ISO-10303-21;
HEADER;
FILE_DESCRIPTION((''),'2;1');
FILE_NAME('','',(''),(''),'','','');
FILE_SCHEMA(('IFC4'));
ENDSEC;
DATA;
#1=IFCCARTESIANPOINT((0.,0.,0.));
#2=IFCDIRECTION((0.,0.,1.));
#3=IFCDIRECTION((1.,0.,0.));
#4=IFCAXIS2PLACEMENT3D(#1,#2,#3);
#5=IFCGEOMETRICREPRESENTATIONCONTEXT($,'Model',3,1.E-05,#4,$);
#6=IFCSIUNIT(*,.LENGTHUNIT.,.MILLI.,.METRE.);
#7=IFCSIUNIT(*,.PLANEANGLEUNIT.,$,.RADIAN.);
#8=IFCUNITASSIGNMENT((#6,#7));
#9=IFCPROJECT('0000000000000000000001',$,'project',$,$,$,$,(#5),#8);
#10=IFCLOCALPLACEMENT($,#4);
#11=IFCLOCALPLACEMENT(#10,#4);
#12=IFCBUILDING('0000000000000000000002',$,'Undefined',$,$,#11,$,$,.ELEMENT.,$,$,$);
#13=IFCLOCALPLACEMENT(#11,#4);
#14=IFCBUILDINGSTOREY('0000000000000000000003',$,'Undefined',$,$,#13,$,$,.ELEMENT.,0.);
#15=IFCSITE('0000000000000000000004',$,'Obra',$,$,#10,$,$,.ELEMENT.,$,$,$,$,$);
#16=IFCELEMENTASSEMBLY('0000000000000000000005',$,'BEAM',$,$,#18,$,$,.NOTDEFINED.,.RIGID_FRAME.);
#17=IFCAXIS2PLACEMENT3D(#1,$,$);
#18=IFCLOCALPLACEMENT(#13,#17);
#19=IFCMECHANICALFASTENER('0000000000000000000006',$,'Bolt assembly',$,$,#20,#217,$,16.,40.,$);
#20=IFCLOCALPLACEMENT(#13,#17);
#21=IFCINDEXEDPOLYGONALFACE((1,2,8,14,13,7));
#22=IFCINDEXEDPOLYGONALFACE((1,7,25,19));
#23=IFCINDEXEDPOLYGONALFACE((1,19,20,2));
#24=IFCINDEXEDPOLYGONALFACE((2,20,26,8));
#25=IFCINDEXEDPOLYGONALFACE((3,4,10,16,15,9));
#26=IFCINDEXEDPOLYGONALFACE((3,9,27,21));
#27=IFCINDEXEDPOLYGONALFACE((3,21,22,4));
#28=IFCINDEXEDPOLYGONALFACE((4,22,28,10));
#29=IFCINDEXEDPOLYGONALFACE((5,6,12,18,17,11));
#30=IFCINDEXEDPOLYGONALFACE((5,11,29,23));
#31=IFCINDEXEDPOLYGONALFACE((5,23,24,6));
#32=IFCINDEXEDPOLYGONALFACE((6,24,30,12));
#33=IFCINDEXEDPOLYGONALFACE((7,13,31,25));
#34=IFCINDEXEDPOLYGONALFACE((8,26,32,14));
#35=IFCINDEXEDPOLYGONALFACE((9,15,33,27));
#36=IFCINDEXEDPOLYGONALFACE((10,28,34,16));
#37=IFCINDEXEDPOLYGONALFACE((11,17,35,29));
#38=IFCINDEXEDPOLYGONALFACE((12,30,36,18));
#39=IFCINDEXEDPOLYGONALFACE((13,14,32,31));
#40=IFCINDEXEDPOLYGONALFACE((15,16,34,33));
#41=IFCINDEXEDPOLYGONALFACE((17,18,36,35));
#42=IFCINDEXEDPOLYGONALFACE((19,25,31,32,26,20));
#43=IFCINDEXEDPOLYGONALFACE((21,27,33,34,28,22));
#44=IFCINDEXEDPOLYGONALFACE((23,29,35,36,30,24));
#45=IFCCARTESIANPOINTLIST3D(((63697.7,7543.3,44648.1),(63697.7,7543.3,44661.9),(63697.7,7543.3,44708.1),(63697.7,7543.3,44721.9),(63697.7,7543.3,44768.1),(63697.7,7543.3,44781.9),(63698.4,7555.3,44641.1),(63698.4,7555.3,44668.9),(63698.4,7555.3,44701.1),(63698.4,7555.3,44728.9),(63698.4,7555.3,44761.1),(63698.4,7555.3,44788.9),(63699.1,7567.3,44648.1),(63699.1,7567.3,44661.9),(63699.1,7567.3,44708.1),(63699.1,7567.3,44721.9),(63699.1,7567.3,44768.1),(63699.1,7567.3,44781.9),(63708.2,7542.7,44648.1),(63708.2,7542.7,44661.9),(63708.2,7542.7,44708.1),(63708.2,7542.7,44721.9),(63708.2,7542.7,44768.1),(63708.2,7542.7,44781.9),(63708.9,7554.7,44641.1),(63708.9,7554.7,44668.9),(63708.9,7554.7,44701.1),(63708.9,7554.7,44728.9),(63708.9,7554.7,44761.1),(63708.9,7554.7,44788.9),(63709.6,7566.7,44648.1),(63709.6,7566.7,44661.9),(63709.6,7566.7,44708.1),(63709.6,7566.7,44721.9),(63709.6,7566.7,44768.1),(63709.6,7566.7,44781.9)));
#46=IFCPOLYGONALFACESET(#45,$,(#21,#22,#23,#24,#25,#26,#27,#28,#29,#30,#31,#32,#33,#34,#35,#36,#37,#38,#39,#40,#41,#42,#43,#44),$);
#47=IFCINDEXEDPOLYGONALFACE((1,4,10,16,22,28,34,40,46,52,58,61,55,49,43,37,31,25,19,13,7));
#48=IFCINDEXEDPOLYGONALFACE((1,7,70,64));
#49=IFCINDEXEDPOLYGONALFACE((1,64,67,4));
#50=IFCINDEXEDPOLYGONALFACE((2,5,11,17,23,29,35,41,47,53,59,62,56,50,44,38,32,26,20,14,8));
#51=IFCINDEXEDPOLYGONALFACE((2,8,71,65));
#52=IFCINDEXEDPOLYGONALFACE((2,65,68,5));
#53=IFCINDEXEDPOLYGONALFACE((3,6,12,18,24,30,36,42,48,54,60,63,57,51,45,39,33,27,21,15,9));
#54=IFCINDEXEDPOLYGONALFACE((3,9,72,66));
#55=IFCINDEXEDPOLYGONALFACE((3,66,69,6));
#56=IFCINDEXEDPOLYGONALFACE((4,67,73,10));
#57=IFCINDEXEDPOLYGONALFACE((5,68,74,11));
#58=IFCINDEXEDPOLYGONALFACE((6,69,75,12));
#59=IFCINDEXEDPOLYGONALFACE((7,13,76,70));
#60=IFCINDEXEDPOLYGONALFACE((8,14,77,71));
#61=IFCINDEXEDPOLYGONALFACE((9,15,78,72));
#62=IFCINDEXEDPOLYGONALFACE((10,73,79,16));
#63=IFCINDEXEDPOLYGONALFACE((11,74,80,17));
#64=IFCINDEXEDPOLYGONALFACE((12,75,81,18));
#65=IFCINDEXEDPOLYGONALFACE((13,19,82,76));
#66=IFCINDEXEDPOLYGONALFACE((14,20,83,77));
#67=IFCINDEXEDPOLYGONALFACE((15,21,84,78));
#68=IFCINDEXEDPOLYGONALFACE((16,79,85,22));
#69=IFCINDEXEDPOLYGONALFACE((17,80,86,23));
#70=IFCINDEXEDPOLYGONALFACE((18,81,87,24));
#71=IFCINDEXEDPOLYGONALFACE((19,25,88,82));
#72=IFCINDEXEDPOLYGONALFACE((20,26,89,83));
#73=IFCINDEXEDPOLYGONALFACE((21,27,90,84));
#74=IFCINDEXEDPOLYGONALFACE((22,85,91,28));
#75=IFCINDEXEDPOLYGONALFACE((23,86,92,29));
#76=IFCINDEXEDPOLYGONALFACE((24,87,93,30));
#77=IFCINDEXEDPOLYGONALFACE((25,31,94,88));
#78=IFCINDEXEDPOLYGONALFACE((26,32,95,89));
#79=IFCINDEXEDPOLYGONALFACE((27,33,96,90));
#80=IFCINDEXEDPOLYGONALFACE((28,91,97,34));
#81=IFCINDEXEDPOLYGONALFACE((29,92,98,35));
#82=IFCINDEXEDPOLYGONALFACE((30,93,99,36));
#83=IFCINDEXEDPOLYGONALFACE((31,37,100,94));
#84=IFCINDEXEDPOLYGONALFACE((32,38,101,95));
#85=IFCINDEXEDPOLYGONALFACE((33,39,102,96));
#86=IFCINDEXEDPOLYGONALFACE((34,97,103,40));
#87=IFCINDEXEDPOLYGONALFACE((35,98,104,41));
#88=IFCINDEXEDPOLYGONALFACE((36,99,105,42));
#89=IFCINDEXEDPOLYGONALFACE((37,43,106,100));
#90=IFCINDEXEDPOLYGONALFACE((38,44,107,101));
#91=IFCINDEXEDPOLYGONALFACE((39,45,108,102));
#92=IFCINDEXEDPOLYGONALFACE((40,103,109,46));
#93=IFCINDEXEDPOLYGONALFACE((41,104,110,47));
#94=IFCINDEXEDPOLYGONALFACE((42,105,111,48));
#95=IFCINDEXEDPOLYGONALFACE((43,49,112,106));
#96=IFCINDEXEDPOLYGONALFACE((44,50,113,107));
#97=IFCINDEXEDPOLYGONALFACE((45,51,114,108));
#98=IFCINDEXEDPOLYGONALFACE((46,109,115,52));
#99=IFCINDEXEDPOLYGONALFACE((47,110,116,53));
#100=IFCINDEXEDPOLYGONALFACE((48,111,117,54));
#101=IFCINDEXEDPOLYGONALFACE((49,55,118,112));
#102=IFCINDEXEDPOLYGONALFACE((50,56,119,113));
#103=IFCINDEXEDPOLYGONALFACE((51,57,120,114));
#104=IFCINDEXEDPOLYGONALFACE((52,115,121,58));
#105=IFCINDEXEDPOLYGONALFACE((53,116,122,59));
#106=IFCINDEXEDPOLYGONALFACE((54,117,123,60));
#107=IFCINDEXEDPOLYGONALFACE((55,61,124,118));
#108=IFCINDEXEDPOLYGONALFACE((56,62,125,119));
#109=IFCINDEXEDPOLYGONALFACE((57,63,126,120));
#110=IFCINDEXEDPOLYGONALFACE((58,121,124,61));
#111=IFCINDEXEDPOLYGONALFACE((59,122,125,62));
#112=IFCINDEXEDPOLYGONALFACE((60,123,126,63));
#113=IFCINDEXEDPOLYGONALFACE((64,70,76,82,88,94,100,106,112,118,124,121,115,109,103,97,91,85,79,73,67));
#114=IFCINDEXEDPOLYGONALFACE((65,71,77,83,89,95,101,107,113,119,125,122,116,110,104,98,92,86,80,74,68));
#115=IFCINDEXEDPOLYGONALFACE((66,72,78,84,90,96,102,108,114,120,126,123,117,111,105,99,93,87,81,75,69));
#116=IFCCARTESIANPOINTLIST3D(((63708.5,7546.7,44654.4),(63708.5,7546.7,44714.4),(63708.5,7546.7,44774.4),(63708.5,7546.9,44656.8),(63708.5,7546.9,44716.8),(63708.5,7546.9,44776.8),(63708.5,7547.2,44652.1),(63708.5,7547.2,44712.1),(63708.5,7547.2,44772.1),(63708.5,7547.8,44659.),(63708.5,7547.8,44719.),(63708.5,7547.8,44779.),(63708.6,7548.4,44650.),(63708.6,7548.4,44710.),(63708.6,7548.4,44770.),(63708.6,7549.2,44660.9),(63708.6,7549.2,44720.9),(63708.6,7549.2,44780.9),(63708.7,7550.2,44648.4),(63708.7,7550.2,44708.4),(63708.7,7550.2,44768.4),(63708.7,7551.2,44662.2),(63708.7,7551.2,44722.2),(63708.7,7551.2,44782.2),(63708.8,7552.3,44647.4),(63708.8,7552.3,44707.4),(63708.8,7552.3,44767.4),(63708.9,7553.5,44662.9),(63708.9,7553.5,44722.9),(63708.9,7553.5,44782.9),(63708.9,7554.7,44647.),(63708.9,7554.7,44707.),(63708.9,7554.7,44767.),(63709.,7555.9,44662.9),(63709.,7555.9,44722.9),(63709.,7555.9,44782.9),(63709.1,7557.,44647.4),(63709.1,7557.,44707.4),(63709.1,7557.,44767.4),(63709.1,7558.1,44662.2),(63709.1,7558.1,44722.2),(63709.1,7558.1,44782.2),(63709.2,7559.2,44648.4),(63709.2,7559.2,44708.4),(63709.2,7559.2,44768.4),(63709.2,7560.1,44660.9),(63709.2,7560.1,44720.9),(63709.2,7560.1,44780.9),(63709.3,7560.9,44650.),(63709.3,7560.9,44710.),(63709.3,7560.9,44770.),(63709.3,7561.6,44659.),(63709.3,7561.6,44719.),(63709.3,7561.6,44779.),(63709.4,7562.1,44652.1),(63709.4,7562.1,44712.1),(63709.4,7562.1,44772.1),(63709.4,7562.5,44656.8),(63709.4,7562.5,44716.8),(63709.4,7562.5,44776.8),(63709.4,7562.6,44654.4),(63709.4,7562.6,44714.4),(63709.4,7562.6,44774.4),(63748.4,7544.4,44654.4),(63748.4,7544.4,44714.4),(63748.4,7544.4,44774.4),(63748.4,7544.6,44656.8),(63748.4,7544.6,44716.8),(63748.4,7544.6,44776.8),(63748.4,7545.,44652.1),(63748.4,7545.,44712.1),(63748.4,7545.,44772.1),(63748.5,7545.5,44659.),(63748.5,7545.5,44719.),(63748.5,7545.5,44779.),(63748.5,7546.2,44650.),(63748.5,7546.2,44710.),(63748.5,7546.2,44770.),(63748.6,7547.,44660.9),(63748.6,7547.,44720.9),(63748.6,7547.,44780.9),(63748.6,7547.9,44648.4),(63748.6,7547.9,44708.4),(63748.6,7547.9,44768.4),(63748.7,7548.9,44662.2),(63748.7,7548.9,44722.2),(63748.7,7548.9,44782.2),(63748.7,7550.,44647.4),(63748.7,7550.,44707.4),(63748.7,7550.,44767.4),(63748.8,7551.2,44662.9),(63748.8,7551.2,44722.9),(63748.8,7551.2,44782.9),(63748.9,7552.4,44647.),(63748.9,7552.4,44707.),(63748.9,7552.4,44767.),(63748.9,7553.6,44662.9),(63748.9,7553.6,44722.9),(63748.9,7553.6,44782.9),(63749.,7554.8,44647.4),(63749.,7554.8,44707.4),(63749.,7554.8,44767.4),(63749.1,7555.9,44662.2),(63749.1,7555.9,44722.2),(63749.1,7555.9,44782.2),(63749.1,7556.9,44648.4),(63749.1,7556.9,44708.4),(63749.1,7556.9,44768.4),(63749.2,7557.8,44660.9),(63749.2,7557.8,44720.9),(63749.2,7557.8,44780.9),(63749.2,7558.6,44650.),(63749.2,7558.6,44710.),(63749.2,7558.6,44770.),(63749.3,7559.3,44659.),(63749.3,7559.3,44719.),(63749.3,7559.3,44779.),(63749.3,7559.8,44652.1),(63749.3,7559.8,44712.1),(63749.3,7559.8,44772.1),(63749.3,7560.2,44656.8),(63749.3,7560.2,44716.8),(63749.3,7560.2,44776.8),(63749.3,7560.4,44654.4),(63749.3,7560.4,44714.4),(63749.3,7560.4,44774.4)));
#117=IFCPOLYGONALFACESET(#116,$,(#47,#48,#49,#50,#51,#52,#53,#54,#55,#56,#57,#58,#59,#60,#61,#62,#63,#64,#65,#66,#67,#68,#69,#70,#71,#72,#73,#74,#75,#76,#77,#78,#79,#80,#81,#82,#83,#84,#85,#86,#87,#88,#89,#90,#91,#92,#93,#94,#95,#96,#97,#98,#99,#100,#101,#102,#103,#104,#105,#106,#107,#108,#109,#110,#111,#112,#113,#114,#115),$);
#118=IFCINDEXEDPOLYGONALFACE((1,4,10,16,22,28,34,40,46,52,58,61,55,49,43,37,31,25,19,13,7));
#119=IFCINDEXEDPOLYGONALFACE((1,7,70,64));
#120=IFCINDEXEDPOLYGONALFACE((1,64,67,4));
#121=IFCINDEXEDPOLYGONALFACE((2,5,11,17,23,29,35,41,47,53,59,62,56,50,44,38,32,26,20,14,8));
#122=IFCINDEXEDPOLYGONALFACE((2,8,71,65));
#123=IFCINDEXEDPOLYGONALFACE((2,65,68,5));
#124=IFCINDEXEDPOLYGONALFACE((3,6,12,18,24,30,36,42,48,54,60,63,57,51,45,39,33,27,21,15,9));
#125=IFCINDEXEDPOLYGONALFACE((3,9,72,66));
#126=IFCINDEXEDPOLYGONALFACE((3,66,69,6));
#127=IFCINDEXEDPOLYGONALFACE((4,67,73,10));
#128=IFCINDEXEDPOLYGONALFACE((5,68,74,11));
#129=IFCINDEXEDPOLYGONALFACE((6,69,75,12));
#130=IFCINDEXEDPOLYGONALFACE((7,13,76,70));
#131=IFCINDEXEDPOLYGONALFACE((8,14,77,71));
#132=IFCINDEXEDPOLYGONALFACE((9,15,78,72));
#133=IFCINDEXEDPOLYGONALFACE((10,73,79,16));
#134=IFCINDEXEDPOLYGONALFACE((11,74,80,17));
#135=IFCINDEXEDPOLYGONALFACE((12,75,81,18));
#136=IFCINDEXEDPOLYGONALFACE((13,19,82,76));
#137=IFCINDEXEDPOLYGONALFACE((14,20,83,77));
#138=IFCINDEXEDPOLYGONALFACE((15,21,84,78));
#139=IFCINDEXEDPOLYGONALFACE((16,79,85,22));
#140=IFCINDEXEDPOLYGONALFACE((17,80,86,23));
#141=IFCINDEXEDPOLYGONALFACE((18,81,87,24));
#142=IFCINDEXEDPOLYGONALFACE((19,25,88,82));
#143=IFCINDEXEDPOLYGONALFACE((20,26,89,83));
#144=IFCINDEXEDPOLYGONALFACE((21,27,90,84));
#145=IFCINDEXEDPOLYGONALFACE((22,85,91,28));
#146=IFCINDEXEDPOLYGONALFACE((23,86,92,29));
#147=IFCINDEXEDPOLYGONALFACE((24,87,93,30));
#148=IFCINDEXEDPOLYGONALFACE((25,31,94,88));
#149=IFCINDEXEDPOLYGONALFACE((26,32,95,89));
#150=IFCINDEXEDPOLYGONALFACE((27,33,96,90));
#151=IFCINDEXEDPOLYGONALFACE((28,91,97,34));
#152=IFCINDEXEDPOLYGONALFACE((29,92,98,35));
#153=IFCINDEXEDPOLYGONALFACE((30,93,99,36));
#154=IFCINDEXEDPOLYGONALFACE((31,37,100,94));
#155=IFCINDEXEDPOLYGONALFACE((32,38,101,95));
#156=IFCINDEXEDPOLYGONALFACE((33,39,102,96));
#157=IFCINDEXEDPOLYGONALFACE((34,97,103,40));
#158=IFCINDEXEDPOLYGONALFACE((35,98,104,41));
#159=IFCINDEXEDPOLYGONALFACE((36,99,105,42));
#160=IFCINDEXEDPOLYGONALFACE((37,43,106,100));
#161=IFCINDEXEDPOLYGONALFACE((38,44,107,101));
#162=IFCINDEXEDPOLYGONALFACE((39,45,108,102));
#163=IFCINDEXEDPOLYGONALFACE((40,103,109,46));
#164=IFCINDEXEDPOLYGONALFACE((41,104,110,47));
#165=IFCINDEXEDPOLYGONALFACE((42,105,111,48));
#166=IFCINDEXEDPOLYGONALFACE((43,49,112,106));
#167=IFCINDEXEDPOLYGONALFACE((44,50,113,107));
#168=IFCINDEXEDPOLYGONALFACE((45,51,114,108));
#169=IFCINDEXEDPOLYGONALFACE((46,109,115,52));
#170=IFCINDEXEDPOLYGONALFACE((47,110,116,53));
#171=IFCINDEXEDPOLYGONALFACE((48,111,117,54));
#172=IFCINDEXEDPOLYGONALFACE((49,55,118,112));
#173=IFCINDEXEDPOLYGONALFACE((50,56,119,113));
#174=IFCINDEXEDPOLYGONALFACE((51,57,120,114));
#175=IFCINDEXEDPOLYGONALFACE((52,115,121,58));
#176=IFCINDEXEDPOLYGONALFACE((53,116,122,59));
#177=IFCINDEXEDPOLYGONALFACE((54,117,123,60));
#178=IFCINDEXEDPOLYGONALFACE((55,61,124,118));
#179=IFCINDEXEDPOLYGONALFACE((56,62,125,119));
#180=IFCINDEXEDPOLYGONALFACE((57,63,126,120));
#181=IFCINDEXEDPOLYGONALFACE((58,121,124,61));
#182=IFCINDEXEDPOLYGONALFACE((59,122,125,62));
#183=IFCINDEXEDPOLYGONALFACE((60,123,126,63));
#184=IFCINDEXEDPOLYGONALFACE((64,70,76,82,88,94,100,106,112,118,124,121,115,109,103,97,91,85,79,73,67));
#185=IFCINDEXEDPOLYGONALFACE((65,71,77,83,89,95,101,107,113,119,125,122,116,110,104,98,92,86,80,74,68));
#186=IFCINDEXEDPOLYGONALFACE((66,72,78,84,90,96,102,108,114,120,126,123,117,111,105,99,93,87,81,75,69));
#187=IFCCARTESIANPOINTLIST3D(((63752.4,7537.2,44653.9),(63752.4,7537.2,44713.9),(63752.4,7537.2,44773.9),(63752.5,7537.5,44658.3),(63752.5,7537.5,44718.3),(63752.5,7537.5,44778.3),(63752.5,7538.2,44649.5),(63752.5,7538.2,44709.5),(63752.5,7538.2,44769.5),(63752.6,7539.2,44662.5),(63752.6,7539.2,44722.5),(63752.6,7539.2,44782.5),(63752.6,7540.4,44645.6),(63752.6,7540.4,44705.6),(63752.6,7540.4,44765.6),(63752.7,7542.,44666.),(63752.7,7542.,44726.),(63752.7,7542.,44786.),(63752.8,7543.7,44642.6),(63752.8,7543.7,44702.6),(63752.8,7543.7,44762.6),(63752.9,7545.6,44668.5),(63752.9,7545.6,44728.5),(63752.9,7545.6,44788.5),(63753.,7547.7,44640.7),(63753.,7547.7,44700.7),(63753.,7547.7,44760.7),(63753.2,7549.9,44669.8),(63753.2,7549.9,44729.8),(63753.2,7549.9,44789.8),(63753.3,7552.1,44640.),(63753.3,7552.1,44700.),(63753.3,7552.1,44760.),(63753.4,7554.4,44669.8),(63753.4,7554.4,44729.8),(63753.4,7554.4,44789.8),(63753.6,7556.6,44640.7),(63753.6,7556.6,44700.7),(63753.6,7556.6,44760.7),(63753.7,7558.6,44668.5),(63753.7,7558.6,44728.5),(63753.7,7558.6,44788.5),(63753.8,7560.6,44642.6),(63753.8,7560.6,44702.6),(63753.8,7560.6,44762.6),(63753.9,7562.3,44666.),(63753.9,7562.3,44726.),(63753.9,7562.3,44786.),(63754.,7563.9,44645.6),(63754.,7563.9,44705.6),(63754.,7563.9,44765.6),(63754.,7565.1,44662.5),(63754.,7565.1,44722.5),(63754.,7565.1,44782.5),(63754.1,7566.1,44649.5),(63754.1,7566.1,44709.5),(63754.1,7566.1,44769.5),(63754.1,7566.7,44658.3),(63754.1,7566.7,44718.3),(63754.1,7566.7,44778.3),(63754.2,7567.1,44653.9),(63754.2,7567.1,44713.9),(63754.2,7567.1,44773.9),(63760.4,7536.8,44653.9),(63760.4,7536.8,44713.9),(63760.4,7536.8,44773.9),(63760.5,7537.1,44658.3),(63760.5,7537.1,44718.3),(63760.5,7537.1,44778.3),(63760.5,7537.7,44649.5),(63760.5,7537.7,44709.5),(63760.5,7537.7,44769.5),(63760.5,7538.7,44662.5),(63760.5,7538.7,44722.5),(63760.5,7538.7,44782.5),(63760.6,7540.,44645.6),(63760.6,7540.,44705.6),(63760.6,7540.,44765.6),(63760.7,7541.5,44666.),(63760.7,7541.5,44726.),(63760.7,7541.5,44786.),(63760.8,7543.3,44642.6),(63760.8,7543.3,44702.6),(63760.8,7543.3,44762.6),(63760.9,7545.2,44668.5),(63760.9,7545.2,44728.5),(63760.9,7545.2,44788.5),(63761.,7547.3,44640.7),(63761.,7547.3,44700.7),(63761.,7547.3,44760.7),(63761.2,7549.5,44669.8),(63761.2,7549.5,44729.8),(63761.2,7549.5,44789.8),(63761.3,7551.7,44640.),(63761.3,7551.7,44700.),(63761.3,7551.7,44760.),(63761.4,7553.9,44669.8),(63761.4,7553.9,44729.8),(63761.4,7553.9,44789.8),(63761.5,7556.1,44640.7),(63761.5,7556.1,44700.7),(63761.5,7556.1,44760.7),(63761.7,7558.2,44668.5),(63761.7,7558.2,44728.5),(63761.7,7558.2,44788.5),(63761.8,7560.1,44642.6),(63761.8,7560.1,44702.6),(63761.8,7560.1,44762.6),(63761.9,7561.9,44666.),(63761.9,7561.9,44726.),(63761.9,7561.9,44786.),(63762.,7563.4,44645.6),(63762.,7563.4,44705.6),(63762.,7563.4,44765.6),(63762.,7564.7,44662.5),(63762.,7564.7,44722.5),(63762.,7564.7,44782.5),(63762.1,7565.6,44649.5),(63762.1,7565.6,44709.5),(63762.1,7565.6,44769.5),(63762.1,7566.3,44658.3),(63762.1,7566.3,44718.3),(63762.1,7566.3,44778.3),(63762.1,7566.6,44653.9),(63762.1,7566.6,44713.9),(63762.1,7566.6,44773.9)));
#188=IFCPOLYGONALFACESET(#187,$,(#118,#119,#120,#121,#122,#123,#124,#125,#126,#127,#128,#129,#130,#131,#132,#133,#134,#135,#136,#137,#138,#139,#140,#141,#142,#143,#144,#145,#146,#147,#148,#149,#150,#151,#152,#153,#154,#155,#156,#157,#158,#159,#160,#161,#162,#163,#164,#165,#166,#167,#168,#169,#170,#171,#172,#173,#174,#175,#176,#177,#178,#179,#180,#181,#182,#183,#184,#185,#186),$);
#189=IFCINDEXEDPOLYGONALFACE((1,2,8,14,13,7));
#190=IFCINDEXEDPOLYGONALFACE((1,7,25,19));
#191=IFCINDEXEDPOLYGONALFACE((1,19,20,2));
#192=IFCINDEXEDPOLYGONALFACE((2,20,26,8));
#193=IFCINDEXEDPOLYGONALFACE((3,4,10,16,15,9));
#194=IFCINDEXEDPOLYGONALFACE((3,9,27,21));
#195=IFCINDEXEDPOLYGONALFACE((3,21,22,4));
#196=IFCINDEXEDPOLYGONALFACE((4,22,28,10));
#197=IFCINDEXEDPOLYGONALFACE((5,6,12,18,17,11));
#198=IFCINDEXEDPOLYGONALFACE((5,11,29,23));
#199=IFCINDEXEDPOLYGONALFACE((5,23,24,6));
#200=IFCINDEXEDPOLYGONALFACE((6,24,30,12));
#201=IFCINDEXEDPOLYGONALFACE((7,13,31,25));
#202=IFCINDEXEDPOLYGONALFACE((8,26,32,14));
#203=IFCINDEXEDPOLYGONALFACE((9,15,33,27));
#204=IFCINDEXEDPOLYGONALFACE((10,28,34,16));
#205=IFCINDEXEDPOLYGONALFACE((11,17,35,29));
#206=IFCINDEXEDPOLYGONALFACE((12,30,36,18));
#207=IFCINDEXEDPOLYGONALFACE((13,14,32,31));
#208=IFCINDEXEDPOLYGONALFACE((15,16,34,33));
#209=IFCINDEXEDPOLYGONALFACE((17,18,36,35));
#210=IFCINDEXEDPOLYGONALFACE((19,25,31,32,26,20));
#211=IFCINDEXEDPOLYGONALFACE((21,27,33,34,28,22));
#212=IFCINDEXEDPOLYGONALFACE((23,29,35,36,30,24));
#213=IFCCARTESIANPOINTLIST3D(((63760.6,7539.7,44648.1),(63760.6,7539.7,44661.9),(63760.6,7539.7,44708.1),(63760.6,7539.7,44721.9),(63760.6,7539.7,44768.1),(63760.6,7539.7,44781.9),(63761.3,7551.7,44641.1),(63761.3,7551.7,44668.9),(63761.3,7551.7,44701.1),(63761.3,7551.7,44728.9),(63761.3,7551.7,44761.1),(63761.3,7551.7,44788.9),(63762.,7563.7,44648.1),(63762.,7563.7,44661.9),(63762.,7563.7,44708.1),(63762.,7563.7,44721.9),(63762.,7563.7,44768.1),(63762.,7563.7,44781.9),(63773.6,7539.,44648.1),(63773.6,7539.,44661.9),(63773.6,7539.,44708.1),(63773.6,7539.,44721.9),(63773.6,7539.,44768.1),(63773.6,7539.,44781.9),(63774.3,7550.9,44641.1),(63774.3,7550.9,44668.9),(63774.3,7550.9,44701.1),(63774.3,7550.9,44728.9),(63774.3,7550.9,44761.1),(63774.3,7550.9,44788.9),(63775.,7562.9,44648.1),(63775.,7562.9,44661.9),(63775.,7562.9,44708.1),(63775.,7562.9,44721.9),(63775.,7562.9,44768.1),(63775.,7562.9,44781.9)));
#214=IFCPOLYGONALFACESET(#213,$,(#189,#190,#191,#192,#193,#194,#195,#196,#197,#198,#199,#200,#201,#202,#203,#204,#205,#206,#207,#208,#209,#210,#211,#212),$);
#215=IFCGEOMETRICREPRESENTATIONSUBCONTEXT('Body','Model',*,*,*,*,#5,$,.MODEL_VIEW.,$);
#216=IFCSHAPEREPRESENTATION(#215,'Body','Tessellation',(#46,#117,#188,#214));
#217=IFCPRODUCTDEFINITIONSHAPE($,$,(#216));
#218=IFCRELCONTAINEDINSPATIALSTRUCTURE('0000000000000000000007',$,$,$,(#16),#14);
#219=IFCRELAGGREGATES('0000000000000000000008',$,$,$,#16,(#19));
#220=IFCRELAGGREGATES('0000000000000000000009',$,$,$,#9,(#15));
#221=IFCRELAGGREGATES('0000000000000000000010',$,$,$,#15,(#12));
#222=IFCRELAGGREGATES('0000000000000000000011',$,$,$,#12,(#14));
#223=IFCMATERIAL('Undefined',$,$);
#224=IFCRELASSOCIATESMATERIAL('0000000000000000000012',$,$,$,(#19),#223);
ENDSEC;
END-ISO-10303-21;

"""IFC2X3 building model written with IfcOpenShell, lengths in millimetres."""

from ifc_helpers import new_model, si_unit, frame, origin_with_axes, origin_2d_with_axis, place, context, subcontext, project, spatial, polyline, circle, outline, extrude, source, transform, mapped, material, element, aggregate, save


model = new_model("IFC2X3")

# Units and contexts
model_context = context("Model", 3, precision=1e-05, world=origin_with_axes())
body_context = subcontext(model_context, "Body", "Model", "MODEL_VIEW")
ifc_project = project(units=[si_unit("LENGTHUNIT", "METRE", prefix="MILLI"), si_unit("PLANEANGLEUNIT", "RADIAN")], contexts=[model_context])

# Site, building, storey
site_placement = place(None, origin_with_axes())
site = spatial("IfcSite", under=ifc_project, at=site_placement, Name="Obra", CompositionType="ELEMENT")
building_placement = place(site_placement, origin_with_axes())
building = spatial("IfcBuilding", under=site, at=building_placement, Name="Undefined", CompositionType="ELEMENT")
storey_placement = place(building_placement, origin_with_axes())
storey = spatial("IfcBuildingStorey", under=building, at=storey_placement, Name="Undefined", CompositionType="ELEMENT", Elevation=0.0)

# Element assembly, mechanical fastener
assembly_1_placement = place(storey_placement, origin_with_axes())
assembly_1 = element("IfcElementAssembly", 1, at=assembly_1_placement, inside=storey, Name="BEAM", AssemblyPlace="NOTDEFINED", PredefinedType="RIGID_FRAME")
ifc_material_1 = material(Name="Undefined")
shared_shape_1 = source(origin_with_axes(), body_context, "Body", "SweptSolid", [
    extrude(outline(polyline([(13.9, 0.0), (6.9, 12.0), (-6.9, 12.0), (-13.9, 0.0), (-6.9, -12.0), (6.9, -12.0), (13.9, 0.0)])), frame((0.0, -19.7, 0.0), z_axis=(0.0, 1.0, 0.0), x_axis=(1.0, 0.0, 0.0)), (0.0, 0.0, 1.0), 10.6),
    extrude(circle(Radius=8.0, at=origin_2d_with_axis()), frame((0.0, -9.1, 0.0), z_axis=(0.0, 1.0, 0.0), x_axis=(1.0, 0.0, 0.0)), (0.0, 0.0, 1.0), 40.0),
    extrude(circle(Radius=15.0, at=origin_2d_with_axis()), frame((0.0, 35.3, 0.0), z_axis=(0.0, 1.0, 0.0), x_axis=(1.0, 0.0, 0.0)), (0.0, 0.0, 1.0), 8.0),
    extrude(outline(polyline([(13.9, 0.0), (6.9, 12.0), (-6.9, 12.0), (-13.9, 0.0), (-6.9, -12.0), (6.9, -12.0), (13.9, 0.0)])), frame((0.0, 43.3, 0.0), z_axis=(0.0, 1.0, 0.0), x_axis=(1.0, 0.0, 0.0)), (0.0, 0.0, 1.0), 13.0),
])
mechanical_fastener_1_placement = place(assembly_1_placement, frame((63720.9, 7604.1, 44835.0), z_axis=(-0.05711, -0.998368, 0.0), x_axis=(0.0, 0.0, -1.0)))
mechanical_fastener_1 = element("IfcMechanicalFastener", 2, at=mechanical_fastener_1_placement, material=ifc_material_1, Name="Bolt assembly", NominalDiameter=16.0, NominalLength=40.0, context=body_context, shape_type="MappedRepresentation", body=[
    mapped(shared_shape_1, transform((60.0, 0.0, 50.0))),
    mapped(shared_shape_1, transform((120.0, 0.0, 50.0))),
    mapped(shared_shape_1, transform((180.0, 0.0, 50.0))),
])
aggregate(assembly_1, [mechanical_fastener_1])

save(model, "model.ifc")
